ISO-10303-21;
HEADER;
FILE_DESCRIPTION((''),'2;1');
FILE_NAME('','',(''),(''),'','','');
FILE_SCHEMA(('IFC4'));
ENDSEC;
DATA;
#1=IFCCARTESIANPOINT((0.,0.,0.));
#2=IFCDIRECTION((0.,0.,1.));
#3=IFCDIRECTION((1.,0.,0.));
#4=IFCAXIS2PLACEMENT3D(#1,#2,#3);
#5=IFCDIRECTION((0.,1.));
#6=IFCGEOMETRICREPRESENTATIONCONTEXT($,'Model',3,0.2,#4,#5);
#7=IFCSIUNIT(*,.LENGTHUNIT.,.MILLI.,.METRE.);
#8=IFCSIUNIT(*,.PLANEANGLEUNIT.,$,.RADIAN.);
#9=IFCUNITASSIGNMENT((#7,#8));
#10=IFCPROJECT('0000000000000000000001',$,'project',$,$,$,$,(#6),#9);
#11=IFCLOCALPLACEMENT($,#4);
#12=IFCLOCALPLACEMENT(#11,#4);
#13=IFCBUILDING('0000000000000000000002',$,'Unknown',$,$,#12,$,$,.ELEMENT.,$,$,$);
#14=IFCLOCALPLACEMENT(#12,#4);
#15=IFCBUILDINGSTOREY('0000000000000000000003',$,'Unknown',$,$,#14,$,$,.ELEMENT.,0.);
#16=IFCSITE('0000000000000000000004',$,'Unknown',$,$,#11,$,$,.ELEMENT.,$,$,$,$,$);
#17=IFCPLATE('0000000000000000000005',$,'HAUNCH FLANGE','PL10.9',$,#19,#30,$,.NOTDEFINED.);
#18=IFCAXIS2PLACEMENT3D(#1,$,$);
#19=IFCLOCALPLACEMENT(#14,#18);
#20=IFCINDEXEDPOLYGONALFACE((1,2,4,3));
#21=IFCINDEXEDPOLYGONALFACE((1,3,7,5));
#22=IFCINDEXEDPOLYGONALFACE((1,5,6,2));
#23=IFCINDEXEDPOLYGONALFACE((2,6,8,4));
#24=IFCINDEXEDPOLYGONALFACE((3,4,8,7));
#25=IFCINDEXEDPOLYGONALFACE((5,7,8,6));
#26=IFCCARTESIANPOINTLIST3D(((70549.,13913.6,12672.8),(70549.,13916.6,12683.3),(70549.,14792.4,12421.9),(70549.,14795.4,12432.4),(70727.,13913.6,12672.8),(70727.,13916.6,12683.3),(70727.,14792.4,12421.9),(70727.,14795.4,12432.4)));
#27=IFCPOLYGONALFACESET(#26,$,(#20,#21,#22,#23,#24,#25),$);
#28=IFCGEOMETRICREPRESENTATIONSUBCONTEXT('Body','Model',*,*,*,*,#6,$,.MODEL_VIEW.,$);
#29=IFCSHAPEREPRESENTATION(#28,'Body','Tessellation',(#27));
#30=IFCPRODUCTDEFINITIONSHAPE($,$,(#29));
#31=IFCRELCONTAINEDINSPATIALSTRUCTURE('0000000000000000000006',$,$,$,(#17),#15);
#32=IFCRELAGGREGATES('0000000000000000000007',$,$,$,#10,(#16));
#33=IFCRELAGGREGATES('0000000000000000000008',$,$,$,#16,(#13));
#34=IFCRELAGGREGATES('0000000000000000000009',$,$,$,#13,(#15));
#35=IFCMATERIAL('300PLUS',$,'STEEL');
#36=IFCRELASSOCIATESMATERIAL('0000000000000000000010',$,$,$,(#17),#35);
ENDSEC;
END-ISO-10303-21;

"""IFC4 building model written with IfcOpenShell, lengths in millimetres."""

from ifc_helpers import new_model, si_unit, direction, frame, origin_with_axes, place, context, subcontext, project, spatial, line, indexed_curve, outline, extrude, material, element, save


model = new_model("IFC4")

# Units and contexts
model_context = context("Model", 3, precision=0.2, world=origin_with_axes(), true_north=direction((0.0, 1.0)))
body_context = subcontext(model_context, "Body", "Model", "MODEL_VIEW")
ifc_project = project(units=[si_unit("LENGTHUNIT", "METRE", prefix="MILLI"), si_unit("PLANEANGLEUNIT", "RADIAN")], contexts=[model_context])

# Site, building, storey
site_placement = place(None, origin_with_axes())
site = spatial("IfcSite", under=ifc_project, at=site_placement, Name="Unknown", CompositionType="ELEMENT")
building_placement = place(site_placement, origin_with_axes())
building = spatial("IfcBuilding", under=site, at=building_placement, Name="Unknown", CompositionType="ELEMENT")
storey_placement = place(building_placement, origin_with_axes())
storey = spatial("IfcBuildingStorey", under=building, at=storey_placement, Name="Unknown", CompositionType="ELEMENT", Elevation=0.0)

# Shared definitions
ifc_material_1 = material(Name="300PLUS", Category="STEEL")

# Plate
plate_1_placement = place(storey_placement, frame((70549.0, 14793.9, 12427.1), z_axis=(0.0, 0.274533, 0.961578), x_axis=(0.0, -0.961578, 0.274533)))
element("IfcPlate", 1, at=plate_1_placement, inside=storey, material=ifc_material_1, Name="HAUNCH FLANGE", Description="PL10.9", PredefinedType="NOTDEFINED", context=body_context, shape_type="SolidModel", body=[
    extrude(outline(indexed_curve([(0.0, 0.0), (913.9, 0.0), (913.9, 178.0), (0.0, 178.0)], segments=[line(1, 2, 3, 4, 1)])), frame((0.0, 0.0, 5.5), z_axis=(0.0, 0.0, 1.0), x_axis=(1.0, 0.0, 0.0)), (0.0, 0.0, -1.0), 10.9),
])

save(model, "model.ifc")
